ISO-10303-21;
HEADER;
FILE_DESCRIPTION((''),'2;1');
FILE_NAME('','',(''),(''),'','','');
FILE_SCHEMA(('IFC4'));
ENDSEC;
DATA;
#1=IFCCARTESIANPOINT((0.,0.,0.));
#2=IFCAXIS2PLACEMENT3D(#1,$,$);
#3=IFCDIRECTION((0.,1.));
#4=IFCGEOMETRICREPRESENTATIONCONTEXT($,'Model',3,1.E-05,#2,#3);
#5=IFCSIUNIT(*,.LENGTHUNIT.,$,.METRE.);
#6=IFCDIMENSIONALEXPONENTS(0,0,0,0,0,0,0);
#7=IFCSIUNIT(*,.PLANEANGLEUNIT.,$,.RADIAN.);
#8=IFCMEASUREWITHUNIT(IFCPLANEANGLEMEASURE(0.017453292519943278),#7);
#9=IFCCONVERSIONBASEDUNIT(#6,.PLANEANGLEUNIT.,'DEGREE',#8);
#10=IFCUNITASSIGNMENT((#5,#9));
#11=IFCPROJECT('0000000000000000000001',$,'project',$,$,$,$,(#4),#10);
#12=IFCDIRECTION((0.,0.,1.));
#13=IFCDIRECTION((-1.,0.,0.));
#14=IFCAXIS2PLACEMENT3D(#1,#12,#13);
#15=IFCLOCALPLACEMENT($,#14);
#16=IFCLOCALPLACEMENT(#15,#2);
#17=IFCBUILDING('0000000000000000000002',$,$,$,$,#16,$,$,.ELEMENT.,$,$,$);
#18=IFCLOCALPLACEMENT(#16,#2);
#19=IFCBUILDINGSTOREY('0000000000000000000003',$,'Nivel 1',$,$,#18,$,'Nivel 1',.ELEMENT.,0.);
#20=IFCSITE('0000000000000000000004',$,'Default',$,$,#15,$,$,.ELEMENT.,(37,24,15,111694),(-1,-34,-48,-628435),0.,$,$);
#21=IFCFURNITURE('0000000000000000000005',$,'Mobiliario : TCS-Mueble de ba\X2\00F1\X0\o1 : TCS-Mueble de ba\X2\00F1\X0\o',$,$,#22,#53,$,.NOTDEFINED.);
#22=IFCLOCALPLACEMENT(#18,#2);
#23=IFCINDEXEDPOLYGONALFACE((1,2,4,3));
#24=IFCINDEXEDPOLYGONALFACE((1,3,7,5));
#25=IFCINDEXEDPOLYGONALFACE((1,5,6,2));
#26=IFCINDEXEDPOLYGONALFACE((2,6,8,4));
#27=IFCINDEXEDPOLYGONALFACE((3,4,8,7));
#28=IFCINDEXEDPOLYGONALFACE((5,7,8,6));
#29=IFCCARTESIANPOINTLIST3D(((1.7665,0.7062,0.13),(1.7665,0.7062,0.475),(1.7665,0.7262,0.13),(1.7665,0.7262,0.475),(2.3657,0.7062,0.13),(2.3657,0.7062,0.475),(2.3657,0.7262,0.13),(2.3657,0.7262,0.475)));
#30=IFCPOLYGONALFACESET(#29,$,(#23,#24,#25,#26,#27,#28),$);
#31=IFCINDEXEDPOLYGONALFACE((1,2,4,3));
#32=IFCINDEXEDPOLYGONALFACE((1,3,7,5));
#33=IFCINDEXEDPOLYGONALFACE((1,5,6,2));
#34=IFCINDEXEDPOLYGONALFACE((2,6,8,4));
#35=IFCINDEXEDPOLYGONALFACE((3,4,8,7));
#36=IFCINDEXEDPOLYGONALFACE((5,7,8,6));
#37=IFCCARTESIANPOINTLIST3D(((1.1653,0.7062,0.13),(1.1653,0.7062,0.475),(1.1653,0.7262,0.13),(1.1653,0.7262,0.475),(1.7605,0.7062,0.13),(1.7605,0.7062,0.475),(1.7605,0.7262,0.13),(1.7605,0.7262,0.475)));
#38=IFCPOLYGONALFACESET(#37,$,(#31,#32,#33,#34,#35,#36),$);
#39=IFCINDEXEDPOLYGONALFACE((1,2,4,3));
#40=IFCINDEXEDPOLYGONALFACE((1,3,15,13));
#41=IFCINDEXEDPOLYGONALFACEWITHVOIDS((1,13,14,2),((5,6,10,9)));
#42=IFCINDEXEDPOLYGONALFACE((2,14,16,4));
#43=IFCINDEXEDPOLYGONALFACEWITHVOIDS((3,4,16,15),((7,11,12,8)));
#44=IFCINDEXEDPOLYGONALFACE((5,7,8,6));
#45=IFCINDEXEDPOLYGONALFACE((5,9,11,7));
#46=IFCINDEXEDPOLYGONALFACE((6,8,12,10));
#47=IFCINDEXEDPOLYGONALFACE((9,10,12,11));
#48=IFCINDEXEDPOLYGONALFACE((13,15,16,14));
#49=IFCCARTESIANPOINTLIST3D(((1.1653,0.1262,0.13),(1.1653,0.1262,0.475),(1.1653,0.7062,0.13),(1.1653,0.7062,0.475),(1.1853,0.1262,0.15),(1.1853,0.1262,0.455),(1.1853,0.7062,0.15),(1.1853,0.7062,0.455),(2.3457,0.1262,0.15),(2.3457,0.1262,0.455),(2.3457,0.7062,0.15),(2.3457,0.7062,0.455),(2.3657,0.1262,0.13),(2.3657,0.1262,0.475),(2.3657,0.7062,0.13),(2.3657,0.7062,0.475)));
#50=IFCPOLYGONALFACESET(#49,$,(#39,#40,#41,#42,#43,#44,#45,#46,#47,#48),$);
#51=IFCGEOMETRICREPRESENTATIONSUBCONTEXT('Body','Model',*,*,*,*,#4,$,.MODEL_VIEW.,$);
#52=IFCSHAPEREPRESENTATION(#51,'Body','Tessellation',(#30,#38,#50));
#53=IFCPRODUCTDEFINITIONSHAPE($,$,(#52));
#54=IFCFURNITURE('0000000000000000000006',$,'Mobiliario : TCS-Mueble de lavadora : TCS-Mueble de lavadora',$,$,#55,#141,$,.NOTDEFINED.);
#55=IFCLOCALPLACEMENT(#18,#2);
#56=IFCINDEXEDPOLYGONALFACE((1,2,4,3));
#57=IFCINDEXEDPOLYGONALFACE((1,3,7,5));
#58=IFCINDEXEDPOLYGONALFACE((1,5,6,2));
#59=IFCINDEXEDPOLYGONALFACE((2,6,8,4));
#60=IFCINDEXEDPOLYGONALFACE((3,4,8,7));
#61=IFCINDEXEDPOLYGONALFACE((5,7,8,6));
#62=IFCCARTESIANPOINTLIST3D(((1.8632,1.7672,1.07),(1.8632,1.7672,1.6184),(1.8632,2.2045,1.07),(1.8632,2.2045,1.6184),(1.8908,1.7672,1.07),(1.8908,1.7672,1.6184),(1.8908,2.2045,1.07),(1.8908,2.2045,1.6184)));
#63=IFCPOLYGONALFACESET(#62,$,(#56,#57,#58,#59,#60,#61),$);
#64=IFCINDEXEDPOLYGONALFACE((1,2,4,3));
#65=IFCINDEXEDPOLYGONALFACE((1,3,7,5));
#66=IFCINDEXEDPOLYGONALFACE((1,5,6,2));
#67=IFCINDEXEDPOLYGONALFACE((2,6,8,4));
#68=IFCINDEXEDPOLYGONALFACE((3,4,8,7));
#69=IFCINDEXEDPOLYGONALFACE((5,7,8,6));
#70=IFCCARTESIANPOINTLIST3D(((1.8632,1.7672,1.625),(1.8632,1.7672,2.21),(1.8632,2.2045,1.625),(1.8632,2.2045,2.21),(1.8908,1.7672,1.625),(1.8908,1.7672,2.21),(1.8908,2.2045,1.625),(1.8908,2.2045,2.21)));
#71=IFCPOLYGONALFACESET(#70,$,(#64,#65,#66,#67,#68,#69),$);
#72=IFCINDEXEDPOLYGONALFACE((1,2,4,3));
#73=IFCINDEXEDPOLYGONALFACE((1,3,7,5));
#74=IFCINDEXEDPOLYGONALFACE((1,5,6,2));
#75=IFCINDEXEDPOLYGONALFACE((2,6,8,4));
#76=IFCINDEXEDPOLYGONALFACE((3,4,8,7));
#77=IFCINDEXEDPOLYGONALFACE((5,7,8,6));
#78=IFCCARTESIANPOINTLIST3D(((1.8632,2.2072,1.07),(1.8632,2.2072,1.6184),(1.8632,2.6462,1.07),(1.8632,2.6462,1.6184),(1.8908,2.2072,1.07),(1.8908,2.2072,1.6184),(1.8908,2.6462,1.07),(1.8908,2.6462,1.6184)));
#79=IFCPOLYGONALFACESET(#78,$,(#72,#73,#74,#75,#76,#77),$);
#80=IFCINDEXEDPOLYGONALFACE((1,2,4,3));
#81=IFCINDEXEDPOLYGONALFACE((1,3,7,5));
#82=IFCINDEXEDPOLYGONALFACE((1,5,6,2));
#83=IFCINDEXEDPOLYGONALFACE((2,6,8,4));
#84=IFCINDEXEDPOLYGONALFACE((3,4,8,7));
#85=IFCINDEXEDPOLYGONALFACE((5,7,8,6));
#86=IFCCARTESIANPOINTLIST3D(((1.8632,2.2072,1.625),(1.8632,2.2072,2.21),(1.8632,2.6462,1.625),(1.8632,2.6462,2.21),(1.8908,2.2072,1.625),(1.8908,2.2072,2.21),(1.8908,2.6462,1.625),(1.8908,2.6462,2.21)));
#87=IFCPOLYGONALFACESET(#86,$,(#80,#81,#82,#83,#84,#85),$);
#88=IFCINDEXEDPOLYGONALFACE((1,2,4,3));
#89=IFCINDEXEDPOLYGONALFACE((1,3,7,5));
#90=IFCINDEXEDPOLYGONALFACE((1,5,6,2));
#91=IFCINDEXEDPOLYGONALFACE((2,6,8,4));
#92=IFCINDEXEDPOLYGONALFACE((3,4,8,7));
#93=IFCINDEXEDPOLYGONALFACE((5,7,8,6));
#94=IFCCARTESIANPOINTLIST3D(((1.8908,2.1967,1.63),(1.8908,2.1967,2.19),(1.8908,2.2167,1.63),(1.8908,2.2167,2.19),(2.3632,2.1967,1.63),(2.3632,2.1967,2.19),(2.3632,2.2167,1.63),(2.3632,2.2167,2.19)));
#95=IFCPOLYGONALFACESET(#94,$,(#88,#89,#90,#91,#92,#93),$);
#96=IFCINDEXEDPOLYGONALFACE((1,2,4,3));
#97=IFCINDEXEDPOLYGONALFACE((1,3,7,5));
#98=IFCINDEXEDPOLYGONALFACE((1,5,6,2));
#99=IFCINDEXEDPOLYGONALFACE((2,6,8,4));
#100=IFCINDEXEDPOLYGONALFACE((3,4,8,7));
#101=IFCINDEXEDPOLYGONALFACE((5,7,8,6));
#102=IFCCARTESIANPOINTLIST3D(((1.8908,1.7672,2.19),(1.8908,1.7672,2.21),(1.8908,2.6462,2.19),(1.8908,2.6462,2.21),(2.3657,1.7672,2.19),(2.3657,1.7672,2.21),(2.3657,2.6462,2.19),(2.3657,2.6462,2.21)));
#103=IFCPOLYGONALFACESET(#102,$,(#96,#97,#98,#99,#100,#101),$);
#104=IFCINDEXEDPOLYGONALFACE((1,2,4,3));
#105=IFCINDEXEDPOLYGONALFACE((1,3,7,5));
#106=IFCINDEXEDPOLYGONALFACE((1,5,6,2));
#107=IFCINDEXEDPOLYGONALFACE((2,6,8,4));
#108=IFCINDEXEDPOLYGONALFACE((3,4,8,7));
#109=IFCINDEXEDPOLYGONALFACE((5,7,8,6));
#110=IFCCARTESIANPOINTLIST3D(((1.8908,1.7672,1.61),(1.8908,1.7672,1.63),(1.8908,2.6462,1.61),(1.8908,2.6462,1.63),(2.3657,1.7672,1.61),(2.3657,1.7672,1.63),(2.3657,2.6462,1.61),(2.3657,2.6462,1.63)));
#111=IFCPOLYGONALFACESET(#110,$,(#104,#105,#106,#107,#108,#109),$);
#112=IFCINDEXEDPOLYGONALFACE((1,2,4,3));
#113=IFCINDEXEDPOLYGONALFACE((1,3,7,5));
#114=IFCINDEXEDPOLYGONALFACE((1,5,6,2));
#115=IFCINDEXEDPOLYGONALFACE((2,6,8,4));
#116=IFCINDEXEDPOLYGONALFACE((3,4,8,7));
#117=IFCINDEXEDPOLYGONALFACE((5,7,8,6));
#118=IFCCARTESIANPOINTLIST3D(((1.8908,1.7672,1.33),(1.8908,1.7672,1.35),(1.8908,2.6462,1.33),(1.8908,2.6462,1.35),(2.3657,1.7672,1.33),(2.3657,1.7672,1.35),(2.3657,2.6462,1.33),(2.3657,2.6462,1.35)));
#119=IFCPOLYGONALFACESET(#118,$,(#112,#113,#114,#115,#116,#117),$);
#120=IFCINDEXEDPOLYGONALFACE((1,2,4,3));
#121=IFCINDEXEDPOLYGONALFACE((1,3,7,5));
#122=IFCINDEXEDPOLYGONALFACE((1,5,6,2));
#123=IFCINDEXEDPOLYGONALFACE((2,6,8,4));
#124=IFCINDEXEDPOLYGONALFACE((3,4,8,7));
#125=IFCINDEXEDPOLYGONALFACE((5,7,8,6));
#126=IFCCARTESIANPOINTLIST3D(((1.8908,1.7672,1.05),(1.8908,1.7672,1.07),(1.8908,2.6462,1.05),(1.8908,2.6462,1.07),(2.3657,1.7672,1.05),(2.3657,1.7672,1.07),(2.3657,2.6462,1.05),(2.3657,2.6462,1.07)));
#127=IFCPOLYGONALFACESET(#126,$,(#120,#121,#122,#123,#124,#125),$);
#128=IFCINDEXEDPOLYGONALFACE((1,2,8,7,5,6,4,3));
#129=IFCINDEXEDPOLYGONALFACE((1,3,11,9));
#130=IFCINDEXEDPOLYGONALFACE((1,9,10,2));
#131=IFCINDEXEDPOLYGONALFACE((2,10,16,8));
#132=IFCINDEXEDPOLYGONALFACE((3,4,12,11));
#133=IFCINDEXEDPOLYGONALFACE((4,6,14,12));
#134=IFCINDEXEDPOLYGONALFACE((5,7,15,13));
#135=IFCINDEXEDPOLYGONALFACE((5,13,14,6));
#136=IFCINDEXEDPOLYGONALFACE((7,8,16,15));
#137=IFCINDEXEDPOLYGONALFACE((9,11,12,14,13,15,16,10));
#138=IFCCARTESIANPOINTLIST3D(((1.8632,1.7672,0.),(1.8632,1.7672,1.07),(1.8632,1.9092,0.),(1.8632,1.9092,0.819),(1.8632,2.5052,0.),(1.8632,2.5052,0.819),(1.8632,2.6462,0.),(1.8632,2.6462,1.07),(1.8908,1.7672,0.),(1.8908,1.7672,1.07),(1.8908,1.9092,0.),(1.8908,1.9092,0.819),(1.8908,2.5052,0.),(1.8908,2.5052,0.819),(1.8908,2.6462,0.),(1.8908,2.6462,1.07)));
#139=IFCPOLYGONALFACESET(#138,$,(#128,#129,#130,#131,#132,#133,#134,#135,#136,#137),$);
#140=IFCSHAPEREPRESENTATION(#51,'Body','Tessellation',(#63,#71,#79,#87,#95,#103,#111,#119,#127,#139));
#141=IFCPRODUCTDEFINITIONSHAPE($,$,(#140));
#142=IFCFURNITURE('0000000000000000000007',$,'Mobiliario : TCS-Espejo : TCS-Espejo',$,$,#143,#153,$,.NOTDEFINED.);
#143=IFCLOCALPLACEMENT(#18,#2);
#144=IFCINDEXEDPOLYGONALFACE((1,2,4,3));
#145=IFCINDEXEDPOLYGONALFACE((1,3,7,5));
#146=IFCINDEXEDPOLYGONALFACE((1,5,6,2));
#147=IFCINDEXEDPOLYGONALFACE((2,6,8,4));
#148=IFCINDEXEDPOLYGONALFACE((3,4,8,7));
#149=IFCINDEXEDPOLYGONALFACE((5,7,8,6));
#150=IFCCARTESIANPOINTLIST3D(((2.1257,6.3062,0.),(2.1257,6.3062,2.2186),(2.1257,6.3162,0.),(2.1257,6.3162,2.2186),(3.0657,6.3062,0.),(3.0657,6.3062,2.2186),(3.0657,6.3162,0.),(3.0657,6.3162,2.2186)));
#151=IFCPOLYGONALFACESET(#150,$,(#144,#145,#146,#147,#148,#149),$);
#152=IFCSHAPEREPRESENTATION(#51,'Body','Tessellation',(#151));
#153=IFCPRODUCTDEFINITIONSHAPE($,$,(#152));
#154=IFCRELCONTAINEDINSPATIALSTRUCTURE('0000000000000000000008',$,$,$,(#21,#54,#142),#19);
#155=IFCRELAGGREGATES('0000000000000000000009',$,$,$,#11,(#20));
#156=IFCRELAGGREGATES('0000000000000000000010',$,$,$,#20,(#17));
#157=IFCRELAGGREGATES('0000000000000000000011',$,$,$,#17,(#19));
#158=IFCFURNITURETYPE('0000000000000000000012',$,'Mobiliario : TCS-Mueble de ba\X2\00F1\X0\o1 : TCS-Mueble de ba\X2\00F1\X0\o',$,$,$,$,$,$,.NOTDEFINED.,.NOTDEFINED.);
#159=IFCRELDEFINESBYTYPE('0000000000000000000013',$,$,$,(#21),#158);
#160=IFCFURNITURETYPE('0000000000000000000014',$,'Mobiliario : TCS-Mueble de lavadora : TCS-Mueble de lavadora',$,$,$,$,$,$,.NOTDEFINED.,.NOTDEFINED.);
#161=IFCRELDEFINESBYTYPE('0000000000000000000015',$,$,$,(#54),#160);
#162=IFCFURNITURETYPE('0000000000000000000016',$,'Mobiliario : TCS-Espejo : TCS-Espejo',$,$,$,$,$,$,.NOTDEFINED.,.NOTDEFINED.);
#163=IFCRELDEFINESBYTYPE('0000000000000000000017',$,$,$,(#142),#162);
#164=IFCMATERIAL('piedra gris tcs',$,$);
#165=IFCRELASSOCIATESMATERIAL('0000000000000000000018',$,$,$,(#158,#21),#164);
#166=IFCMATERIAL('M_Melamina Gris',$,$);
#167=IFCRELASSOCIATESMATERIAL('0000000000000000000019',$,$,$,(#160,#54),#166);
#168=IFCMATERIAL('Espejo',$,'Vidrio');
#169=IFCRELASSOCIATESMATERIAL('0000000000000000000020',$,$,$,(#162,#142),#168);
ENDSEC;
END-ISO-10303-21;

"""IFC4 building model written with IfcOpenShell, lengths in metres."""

from ifc_helpers import new_model, entity, si_unit, converted_unit, direction, frame, origin, place, context, subcontext, project, spatial, indexed_curve, outline, extrude, source, transform, mapped, material, type_object, type_shapes, element, save


model = new_model("IFC4")

# Units and contexts
model_context = context("Model", 3, precision=1e-05, world=origin(), true_north=direction((0.0, 1.0)))
body_context = subcontext(model_context, "Body", "Model", "MODEL_VIEW")
ifc_project = project(units=[si_unit("LENGTHUNIT", "METRE"), converted_unit("PLANEANGLEUNIT", "DEGREE", entity("IfcPlaneAngleMeasure", 0.017453292519943278), si_unit("PLANEANGLEUNIT", "RADIAN"), dimensions=[0, 0, 0, 0, 0, 0, 0])], contexts=[model_context])

# Site, building, storey
site_placement = place(None, frame((0.0, 0.0, 0.0), z_axis=(0.0, 0.0, 1.0), x_axis=(-1.0, 0.0, 0.0)))
site = spatial("IfcSite", under=ifc_project, at=site_placement, Name="Default", CompositionType="ELEMENT", RefLatitude=(37, 24, 15, 111694), RefLongitude=(-1, -34, -48, -628435), RefElevation=0.0)
building_placement = place(site_placement, origin())
building = spatial("IfcBuilding", under=site, at=building_placement, CompositionType="ELEMENT")
storey_placement = place(building_placement, origin())
storey = spatial("IfcBuildingStorey", under=building, at=storey_placement, Name="Nivel 1", LongName="Nivel 1", CompositionType="ELEMENT", Elevation=0.0)

# Furniture
ifc_material_1 = material(Name="M_Melamina Gris")
ifc_material_2 = material(Name="piedra gris tcs")
furniture_type_1 = type_object("IfcFurnitureType", Name="Mobiliario : TCS-Mueble de baño1 : TCS-Mueble de baño", AssemblyPlace="NOTDEFINED", PredefinedType="NOTDEFINED", material=ifc_material_2)
shared_shape_1 = source(origin(), body_context, "Body", "SweptSolid", [
    extrude(outline(indexed_curve([(-0.01, -0.2996), (0.01, -0.2996), (0.01, 0.2996), (-0.01, 0.2996), (-0.01, -0.2996)], self_intersect=False)), frame((2.0661, 0.7162, 0.15), z_axis=(0.0, 0.0, 1.0), x_axis=(0.0, -1.0, 0.0)), (0.0, 0.0, 1.0), 0.345),
    extrude(outline(indexed_curve([(-0.01, -0.2976), (0.01, -0.2976), (0.01, 0.2976), (-0.01, 0.2976), (-0.01, -0.2976)], self_intersect=False)), frame((1.4629, 0.7162, 0.15), z_axis=(0.0, 0.0, 1.0), x_axis=(0.0, -1.0, 0.0)), (0.0, 0.0, 1.0), 0.345),
    extrude(outline(indexed_curve([(-0.1725, -0.6002), (0.1725, -0.6002), (0.1725, 0.6002), (-0.1725, 0.6002), (-0.1725, -0.6002)], self_intersect=False), holes=[indexed_curve([(-0.1525, 0.5802), (0.1525, 0.5802), (0.1525, -0.5802), (-0.1525, -0.5802), (-0.1525, 0.5802)], self_intersect=False)]), frame((1.7655, 0.1262, 0.3225), z_axis=(0.0, 1.0, 0.0), x_axis=(0.0, 0.0, -1.0)), (0.0, 0.0, 1.0), 0.58),
])
type_shapes(furniture_type_1, [shared_shape_1])
furniture_1_placement = place(storey_placement, frame((0.0, 0.0, -0.02)))
element("IfcFurniture", 1, at=furniture_1_placement, inside=storey, type_object=furniture_type_1, material=ifc_material_2, Name="Mobiliario : TCS-Mueble de baño1 : TCS-Mueble de baño", PredefinedType="NOTDEFINED", context=body_context, shape_type="MappedRepresentation", body=[
    mapped(shared_shape_1, transform((0.0, 0.0, 0.0), scale=1.0)),
])
furniture_type_2 = type_object("IfcFurnitureType", Name="Mobiliario : TCS-Mueble de lavadora : TCS-Mueble de lavadora", AssemblyPlace="NOTDEFINED", PredefinedType="NOTDEFINED", material=ifc_material_1)
shared_shape_2 = source(origin(), body_context, "Body", "SweptSolid", [
    extrude(outline(indexed_curve([(-0.0138, -0.2187), (0.0138, -0.2187), (0.0138, 0.2187), (-0.0138, 0.2187), (-0.0138, -0.2187)], self_intersect=False)), frame((1.877, 1.9858, 1.07)), (0.0, 0.0, 1.0), 0.5484),
    extrude(outline(indexed_curve([(-0.0138, -0.2187), (0.0138, -0.2187), (0.0138, 0.2187), (-0.0138, 0.2187), (-0.0138, -0.2187)], self_intersect=False)), frame((1.877, 1.9858, 1.625)), (0.0, 0.0, 1.0), 0.585),
    extrude(outline(indexed_curve([(-0.0138, -0.2195), (0.0138, -0.2195), (0.0138, 0.2195), (-0.0138, 0.2195), (-0.0138, -0.2195)], self_intersect=False)), frame((1.877, 2.4267, 1.07)), (0.0, 0.0, 1.0), 0.5484),
    extrude(outline(indexed_curve([(-0.0138, -0.2195), (0.0138, -0.2195), (0.0138, 0.2195), (-0.0138, 0.2195), (-0.0138, -0.2195)], self_intersect=False)), frame((1.877, 2.4267, 1.625)), (0.0, 0.0, 1.0), 0.585),
    extrude(outline(indexed_curve([(-0.2362, -0.01), (0.2362, -0.01), (0.2362, 0.01), (-0.2362, 0.01), (-0.2362, -0.01)], self_intersect=False)), frame((2.127, 2.2067, 1.63)), (0.0, 0.0, 1.0), 0.56),
    extrude(outline(indexed_curve([(-0.2375, -0.4395), (0.2375, -0.4395), (0.2375, 0.4395), (-0.2375, 0.4395), (-0.2375, -0.4395)], self_intersect=False)), frame((2.1282, 2.2067, 2.19), z_axis=(0.0, 0.0, 1.0), x_axis=(-1.0, 0.0, 0.0)), (0.0, 0.0, 1.0), 0.02),
    extrude(outline(indexed_curve([(-0.2375, -0.4395), (0.2375, -0.4395), (0.2375, 0.4395), (-0.2375, 0.4395), (-0.2375, -0.4395)], self_intersect=False)), frame((2.1282, 2.2067, 1.61), z_axis=(0.0, 0.0, 1.0), x_axis=(-1.0, 0.0, 0.0)), (0.0, 0.0, 1.0), 0.02),
    extrude(outline(indexed_curve([(-0.2375, -0.4395), (0.2375, -0.4395), (0.2375, 0.4395), (-0.2375, 0.4395), (-0.2375, -0.4395)], self_intersect=False)), frame((2.1282, 2.2067, 1.33), z_axis=(0.0, 0.0, 1.0), x_axis=(-1.0, 0.0, 0.0)), (0.0, 0.0, 1.0), 0.02),
    extrude(outline(indexed_curve([(-0.2375, -0.4395), (0.2375, -0.4395), (0.2375, 0.4395), (-0.2375, 0.4395), (-0.2375, -0.4395)], self_intersect=False)), frame((2.1282, 2.2067, 1.05), z_axis=(0.0, 0.0, 1.0), x_axis=(-1.0, 0.0, 0.0)), (0.0, 0.0, 1.0), 0.02),
    extrude(outline(indexed_curve([(0.2983, -0.4723), (0.4393, -0.4723), (0.4393, 0.5977), (-0.4398, 0.5977), (-0.4398, -0.4723), (-0.2978, -0.4723), (-0.2978, 0.3468), (0.2983, 0.3468), (0.2983, -0.4723)], self_intersect=False)), frame((1.8632, 2.2069, 0.4723), z_axis=(1.0, 0.0, 0.0), x_axis=(0.0, 1.0, 0.0)), (0.0, 0.0, 1.0), 0.0276),
])
type_shapes(furniture_type_2, [shared_shape_2])
furniture_2_placement = place(storey_placement, origin())
element("IfcFurniture", 2, at=furniture_2_placement, inside=storey, type_object=furniture_type_2, material=ifc_material_1, Name="Mobiliario : TCS-Mueble de lavadora : TCS-Mueble de lavadora", PredefinedType="NOTDEFINED", context=body_context, shape_type="MappedRepresentation", body=[
    mapped(shared_shape_2, transform((0.0, 0.0, 0.0), scale=1.0)),
])
ifc_material_3 = material(Name="Espejo", Category="Vidrio")
furniture_type_3 = type_object("IfcFurnitureType", Name="Mobiliario : TCS-Espejo : TCS-Espejo", AssemblyPlace="NOTDEFINED", PredefinedType="NOTDEFINED", material=ifc_material_3)
shared_shape_3 = source(origin(), body_context, "Body", "SweptSolid", [
    extrude(outline(indexed_curve([(-0.47, -0.005), (0.47, -0.005), (0.47, 0.005), (-0.47, 0.005), (-0.47, -0.005)], self_intersect=False)), frame((2.5957, 6.3112, 0.0), z_axis=(0.0, 0.0, 1.0), x_axis=(-1.0, 0.0, 0.0)), (0.0, 0.0, 1.0), 2.2186),
])
type_shapes(furniture_type_3, [shared_shape_3])
furniture_3_placement = place(storey_placement, origin())
element("IfcFurniture", 3, at=furniture_3_placement, inside=storey, type_object=furniture_type_3, material=ifc_material_3, Name="Mobiliario : TCS-Espejo : TCS-Espejo", PredefinedType="NOTDEFINED", context=body_context, shape_type="MappedRepresentation", body=[
    mapped(shared_shape_3, transform((0.0, 0.0, 0.0), scale=1.0)),
])

save(model, "model.ifc")
